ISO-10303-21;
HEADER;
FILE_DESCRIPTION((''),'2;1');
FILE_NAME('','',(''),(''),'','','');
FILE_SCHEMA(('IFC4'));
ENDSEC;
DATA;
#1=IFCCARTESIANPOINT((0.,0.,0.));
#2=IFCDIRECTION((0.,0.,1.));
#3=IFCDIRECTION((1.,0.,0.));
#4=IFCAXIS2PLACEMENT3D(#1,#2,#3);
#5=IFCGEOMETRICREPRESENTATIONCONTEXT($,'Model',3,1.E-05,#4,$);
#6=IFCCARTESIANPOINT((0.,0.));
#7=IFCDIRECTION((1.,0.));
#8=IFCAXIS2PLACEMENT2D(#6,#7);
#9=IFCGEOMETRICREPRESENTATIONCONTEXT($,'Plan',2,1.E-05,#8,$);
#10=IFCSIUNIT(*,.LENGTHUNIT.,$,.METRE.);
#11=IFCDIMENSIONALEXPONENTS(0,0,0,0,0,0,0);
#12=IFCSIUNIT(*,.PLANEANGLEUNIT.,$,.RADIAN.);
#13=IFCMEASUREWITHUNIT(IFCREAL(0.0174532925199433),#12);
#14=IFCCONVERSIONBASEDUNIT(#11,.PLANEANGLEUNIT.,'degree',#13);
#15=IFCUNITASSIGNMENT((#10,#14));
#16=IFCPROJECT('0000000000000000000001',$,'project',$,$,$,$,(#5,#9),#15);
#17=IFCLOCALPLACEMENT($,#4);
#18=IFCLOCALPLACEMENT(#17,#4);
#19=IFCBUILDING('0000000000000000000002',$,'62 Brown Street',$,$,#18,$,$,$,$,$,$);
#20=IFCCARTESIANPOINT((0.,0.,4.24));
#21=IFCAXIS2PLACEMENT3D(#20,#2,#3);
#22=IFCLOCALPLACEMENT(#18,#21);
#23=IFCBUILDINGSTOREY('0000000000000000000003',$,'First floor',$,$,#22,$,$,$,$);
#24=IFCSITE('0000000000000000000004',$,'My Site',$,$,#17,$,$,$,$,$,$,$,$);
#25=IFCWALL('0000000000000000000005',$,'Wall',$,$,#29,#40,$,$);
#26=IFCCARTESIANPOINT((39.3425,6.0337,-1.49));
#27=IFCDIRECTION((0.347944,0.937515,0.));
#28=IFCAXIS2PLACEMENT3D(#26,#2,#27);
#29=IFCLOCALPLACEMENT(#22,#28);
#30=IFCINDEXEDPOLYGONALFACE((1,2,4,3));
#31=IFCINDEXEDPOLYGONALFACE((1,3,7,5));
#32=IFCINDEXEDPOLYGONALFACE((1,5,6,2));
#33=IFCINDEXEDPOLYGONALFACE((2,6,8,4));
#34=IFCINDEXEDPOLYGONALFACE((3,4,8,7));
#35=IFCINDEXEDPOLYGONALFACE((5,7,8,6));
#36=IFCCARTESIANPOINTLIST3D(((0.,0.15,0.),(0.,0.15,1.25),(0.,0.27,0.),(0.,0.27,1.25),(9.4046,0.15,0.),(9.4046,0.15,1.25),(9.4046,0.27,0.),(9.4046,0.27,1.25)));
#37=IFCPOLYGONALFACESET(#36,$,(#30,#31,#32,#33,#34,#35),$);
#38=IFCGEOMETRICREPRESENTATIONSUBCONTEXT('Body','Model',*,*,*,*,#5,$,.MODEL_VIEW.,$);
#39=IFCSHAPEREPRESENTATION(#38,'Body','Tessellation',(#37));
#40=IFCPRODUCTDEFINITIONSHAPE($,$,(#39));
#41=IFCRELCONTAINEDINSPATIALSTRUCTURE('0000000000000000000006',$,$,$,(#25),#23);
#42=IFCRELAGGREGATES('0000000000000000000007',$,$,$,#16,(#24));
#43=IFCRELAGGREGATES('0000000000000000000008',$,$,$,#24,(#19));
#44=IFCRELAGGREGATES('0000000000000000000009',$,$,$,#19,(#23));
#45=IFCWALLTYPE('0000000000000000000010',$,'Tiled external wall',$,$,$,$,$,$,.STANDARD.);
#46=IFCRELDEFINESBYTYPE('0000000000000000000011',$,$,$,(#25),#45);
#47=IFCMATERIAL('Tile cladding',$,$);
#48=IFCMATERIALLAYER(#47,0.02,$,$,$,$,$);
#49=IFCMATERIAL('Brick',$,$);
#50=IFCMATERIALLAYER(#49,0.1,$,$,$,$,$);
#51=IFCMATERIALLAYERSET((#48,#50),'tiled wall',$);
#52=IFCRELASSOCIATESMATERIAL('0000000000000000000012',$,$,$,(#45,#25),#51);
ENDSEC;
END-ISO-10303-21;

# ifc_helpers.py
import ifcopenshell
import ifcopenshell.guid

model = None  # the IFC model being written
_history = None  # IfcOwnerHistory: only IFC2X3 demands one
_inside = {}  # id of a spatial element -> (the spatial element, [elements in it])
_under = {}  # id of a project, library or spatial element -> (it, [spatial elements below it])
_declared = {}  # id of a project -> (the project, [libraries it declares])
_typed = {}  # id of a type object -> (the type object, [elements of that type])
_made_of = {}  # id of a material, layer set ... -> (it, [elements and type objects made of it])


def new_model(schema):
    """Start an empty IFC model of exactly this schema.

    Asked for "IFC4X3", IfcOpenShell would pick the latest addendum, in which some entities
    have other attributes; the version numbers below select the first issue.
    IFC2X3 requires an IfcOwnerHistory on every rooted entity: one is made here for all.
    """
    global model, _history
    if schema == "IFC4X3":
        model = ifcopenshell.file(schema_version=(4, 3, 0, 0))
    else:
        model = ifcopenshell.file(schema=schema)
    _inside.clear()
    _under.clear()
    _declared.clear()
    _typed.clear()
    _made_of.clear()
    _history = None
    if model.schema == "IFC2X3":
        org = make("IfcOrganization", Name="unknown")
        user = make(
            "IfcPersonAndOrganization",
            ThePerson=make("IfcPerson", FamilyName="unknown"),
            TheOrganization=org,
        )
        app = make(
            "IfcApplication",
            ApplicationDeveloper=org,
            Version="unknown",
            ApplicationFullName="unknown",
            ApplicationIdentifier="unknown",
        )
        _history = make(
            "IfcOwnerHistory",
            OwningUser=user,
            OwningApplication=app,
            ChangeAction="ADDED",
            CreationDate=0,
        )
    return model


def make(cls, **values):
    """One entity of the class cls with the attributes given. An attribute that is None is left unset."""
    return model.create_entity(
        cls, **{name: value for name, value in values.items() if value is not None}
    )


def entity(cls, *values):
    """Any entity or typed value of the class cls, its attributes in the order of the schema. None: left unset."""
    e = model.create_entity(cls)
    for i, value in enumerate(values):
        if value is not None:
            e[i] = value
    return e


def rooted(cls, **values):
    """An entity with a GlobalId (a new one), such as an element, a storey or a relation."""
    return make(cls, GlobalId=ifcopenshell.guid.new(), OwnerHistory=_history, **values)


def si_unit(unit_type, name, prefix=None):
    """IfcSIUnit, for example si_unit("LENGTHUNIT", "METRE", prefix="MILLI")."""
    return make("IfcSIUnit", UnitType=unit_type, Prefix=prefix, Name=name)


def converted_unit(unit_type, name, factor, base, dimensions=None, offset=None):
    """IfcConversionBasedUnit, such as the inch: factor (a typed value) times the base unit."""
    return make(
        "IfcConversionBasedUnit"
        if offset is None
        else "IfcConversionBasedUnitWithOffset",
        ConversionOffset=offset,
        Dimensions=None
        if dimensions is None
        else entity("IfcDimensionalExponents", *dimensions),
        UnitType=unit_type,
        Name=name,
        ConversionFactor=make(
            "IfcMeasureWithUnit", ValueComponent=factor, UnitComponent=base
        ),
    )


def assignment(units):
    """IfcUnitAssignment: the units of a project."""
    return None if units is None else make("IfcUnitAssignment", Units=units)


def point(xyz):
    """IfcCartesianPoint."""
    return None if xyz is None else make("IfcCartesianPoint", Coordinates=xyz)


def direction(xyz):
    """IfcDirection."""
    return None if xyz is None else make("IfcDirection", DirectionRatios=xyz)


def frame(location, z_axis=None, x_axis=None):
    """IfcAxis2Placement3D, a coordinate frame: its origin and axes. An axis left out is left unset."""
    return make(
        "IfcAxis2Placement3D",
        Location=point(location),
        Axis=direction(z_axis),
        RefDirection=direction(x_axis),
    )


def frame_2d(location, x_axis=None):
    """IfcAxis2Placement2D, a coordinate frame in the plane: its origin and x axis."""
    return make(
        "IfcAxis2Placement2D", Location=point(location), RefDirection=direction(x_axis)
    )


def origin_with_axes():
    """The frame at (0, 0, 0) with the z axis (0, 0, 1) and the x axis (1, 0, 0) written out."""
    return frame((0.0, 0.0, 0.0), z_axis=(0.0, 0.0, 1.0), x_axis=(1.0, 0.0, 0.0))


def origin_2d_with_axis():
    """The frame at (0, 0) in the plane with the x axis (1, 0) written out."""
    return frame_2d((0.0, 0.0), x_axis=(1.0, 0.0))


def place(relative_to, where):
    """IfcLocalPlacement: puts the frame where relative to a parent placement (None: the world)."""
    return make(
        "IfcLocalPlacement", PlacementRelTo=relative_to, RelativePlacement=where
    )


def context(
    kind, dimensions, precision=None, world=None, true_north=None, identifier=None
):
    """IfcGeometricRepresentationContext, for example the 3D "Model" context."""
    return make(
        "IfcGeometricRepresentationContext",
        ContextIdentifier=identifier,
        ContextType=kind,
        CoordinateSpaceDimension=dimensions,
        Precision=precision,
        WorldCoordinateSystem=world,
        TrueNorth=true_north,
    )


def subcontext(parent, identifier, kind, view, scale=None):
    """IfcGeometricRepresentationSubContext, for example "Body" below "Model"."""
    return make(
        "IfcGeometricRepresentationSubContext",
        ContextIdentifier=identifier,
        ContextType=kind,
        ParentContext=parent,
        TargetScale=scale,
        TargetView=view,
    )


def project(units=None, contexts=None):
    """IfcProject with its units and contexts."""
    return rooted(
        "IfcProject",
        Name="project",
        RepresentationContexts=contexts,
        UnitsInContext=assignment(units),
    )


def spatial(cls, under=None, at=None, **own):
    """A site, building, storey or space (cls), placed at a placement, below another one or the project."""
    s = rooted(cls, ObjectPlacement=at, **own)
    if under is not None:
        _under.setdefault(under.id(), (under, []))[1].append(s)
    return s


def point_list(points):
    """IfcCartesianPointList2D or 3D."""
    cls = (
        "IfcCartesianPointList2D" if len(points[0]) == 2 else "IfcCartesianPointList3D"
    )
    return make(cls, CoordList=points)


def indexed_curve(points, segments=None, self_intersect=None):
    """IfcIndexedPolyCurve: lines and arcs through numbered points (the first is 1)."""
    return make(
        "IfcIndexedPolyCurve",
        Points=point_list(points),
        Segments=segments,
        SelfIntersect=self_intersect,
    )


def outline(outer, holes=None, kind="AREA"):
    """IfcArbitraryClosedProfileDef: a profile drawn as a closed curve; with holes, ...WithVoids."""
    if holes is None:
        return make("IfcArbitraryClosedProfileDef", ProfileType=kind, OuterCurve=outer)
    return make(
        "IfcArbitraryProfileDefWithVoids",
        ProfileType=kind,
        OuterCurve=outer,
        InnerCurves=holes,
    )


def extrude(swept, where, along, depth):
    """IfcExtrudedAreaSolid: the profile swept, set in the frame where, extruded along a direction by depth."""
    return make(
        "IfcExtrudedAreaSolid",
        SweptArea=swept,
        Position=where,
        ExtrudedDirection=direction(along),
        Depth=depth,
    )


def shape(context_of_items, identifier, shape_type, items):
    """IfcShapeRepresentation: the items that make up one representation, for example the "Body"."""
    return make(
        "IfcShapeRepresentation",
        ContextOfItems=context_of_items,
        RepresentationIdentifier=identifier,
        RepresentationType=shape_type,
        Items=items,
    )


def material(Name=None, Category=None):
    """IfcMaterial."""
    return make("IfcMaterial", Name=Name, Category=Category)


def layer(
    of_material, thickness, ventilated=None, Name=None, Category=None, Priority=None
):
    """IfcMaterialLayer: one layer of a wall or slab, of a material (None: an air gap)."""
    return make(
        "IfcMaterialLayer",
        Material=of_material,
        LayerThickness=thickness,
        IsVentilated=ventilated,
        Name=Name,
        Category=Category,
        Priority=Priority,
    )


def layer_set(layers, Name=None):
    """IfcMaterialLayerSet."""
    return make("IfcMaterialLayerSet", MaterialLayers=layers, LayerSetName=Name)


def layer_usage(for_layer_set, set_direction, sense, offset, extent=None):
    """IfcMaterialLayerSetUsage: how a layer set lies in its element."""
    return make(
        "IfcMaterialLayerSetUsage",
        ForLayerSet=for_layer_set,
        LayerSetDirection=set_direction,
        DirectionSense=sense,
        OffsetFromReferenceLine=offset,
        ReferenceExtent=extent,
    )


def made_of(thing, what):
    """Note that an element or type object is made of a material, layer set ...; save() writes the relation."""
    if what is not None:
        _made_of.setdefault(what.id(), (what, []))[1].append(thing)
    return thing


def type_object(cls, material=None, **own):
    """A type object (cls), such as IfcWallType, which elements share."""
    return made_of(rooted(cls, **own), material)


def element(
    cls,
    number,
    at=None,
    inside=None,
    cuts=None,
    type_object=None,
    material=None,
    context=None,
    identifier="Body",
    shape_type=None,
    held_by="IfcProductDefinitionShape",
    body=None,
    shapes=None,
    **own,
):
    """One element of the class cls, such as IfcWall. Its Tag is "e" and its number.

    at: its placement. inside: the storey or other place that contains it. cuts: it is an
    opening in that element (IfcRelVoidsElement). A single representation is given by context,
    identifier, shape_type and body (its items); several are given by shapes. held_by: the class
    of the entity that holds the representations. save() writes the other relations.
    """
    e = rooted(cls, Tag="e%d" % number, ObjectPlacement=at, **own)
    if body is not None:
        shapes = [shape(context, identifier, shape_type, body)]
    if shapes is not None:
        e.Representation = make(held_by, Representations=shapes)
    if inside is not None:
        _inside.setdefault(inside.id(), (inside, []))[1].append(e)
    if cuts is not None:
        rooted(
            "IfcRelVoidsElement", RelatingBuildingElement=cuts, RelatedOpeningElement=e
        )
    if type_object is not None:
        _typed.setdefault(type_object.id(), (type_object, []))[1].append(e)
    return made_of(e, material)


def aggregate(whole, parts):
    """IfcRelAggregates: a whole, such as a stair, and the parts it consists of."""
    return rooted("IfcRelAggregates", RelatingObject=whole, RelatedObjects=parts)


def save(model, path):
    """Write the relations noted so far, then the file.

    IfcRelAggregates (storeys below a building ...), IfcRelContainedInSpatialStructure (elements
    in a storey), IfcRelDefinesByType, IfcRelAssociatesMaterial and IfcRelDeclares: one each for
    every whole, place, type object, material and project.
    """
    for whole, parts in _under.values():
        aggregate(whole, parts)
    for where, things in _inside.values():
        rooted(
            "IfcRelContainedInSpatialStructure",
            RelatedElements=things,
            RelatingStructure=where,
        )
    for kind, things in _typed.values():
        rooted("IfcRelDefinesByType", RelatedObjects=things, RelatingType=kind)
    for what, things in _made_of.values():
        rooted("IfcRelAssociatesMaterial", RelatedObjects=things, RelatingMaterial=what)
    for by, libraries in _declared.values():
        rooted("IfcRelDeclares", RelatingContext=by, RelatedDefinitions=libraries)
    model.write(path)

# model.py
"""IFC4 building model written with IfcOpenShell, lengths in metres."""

from ifc_helpers import new_model, entity, si_unit, converted_unit, frame, origin_with_axes, origin_2d_with_axis, place, context, subcontext, project, spatial, indexed_curve, outline, extrude, material, layer, layer_set, layer_usage, type_object, element, save


model = new_model("IFC4")

# Units and contexts
model_context = context("Model", 3, precision=1e-05, world=origin_with_axes())
plan_context = context("Plan", 2, precision=1e-05, world=origin_2d_with_axis())
body_context_1 = subcontext(model_context, "Body", "Model", "MODEL_VIEW")
ifc_project = project(units=[si_unit("LENGTHUNIT", "METRE"), converted_unit("PLANEANGLEUNIT", "degree", entity("IfcReal", 0.0174532925199433), si_unit("PLANEANGLEUNIT", "RADIAN"), dimensions=[0, 0, 0, 0, 0, 0, 0])], contexts=[model_context, plan_context])

# Site, building, storey
site_placement = place(None, origin_with_axes())
site = spatial("IfcSite", under=ifc_project, at=site_placement, Name="My Site")
building_placement = place(site_placement, origin_with_axes())
building = spatial("IfcBuilding", under=site, at=building_placement, Name="62 Brown Street")
storey_placement = place(building_placement, frame((0.0, 0.0, 4.24), z_axis=(0.0, 0.0, 1.0), x_axis=(1.0, 0.0, 0.0)))
storey = spatial("IfcBuildingStorey", under=building, at=storey_placement, Name="First floor")

# Shared definitions
ifc_material_1 = material(Name="Brick")

# Wall
ifc_material_2 = material(Name="Tile cladding")
ifc_layer_1 = layer(ifc_material_2, 0.02)
ifc_layer_2 = layer(ifc_material_1, 0.1)
ifc_layer_set_1 = layer_set([ifc_layer_1, ifc_layer_2], Name="tiled wall")
ifc_layer_usage_1 = layer_usage(ifc_layer_set_1, "AXIS2", "POSITIVE", 0.15)
wall_type_1 = type_object("IfcWallType", Name="Tiled external wall", PredefinedType="STANDARD", material=ifc_layer_set_1)
wall_1_placement = place(storey_placement, frame((39.3425, 6.0337, -1.49), z_axis=(0.0, 0.0, 1.0), x_axis=(0.347944, 0.937515, 0.0)))
element("IfcWall", 1, at=wall_1_placement, inside=storey, type_object=wall_type_1, material=ifc_layer_usage_1, Name="Wall", context=body_context_1, shape_type="SweptSolid", body=[
    extrude(outline(indexed_curve([(0.0, 0.0), (0.0, 0.12), (9.4046, 0.12), (9.4046, 0.0), (0.0, 0.0)], self_intersect=False)), frame((0.0, 0.15, 0.0), z_axis=(0.0, 0.0, 1.0), x_axis=(1.0, 0.0, 0.0)), (0.0, 0.0, 1.0), 1.25),
])

save(model, "model.ifc")
